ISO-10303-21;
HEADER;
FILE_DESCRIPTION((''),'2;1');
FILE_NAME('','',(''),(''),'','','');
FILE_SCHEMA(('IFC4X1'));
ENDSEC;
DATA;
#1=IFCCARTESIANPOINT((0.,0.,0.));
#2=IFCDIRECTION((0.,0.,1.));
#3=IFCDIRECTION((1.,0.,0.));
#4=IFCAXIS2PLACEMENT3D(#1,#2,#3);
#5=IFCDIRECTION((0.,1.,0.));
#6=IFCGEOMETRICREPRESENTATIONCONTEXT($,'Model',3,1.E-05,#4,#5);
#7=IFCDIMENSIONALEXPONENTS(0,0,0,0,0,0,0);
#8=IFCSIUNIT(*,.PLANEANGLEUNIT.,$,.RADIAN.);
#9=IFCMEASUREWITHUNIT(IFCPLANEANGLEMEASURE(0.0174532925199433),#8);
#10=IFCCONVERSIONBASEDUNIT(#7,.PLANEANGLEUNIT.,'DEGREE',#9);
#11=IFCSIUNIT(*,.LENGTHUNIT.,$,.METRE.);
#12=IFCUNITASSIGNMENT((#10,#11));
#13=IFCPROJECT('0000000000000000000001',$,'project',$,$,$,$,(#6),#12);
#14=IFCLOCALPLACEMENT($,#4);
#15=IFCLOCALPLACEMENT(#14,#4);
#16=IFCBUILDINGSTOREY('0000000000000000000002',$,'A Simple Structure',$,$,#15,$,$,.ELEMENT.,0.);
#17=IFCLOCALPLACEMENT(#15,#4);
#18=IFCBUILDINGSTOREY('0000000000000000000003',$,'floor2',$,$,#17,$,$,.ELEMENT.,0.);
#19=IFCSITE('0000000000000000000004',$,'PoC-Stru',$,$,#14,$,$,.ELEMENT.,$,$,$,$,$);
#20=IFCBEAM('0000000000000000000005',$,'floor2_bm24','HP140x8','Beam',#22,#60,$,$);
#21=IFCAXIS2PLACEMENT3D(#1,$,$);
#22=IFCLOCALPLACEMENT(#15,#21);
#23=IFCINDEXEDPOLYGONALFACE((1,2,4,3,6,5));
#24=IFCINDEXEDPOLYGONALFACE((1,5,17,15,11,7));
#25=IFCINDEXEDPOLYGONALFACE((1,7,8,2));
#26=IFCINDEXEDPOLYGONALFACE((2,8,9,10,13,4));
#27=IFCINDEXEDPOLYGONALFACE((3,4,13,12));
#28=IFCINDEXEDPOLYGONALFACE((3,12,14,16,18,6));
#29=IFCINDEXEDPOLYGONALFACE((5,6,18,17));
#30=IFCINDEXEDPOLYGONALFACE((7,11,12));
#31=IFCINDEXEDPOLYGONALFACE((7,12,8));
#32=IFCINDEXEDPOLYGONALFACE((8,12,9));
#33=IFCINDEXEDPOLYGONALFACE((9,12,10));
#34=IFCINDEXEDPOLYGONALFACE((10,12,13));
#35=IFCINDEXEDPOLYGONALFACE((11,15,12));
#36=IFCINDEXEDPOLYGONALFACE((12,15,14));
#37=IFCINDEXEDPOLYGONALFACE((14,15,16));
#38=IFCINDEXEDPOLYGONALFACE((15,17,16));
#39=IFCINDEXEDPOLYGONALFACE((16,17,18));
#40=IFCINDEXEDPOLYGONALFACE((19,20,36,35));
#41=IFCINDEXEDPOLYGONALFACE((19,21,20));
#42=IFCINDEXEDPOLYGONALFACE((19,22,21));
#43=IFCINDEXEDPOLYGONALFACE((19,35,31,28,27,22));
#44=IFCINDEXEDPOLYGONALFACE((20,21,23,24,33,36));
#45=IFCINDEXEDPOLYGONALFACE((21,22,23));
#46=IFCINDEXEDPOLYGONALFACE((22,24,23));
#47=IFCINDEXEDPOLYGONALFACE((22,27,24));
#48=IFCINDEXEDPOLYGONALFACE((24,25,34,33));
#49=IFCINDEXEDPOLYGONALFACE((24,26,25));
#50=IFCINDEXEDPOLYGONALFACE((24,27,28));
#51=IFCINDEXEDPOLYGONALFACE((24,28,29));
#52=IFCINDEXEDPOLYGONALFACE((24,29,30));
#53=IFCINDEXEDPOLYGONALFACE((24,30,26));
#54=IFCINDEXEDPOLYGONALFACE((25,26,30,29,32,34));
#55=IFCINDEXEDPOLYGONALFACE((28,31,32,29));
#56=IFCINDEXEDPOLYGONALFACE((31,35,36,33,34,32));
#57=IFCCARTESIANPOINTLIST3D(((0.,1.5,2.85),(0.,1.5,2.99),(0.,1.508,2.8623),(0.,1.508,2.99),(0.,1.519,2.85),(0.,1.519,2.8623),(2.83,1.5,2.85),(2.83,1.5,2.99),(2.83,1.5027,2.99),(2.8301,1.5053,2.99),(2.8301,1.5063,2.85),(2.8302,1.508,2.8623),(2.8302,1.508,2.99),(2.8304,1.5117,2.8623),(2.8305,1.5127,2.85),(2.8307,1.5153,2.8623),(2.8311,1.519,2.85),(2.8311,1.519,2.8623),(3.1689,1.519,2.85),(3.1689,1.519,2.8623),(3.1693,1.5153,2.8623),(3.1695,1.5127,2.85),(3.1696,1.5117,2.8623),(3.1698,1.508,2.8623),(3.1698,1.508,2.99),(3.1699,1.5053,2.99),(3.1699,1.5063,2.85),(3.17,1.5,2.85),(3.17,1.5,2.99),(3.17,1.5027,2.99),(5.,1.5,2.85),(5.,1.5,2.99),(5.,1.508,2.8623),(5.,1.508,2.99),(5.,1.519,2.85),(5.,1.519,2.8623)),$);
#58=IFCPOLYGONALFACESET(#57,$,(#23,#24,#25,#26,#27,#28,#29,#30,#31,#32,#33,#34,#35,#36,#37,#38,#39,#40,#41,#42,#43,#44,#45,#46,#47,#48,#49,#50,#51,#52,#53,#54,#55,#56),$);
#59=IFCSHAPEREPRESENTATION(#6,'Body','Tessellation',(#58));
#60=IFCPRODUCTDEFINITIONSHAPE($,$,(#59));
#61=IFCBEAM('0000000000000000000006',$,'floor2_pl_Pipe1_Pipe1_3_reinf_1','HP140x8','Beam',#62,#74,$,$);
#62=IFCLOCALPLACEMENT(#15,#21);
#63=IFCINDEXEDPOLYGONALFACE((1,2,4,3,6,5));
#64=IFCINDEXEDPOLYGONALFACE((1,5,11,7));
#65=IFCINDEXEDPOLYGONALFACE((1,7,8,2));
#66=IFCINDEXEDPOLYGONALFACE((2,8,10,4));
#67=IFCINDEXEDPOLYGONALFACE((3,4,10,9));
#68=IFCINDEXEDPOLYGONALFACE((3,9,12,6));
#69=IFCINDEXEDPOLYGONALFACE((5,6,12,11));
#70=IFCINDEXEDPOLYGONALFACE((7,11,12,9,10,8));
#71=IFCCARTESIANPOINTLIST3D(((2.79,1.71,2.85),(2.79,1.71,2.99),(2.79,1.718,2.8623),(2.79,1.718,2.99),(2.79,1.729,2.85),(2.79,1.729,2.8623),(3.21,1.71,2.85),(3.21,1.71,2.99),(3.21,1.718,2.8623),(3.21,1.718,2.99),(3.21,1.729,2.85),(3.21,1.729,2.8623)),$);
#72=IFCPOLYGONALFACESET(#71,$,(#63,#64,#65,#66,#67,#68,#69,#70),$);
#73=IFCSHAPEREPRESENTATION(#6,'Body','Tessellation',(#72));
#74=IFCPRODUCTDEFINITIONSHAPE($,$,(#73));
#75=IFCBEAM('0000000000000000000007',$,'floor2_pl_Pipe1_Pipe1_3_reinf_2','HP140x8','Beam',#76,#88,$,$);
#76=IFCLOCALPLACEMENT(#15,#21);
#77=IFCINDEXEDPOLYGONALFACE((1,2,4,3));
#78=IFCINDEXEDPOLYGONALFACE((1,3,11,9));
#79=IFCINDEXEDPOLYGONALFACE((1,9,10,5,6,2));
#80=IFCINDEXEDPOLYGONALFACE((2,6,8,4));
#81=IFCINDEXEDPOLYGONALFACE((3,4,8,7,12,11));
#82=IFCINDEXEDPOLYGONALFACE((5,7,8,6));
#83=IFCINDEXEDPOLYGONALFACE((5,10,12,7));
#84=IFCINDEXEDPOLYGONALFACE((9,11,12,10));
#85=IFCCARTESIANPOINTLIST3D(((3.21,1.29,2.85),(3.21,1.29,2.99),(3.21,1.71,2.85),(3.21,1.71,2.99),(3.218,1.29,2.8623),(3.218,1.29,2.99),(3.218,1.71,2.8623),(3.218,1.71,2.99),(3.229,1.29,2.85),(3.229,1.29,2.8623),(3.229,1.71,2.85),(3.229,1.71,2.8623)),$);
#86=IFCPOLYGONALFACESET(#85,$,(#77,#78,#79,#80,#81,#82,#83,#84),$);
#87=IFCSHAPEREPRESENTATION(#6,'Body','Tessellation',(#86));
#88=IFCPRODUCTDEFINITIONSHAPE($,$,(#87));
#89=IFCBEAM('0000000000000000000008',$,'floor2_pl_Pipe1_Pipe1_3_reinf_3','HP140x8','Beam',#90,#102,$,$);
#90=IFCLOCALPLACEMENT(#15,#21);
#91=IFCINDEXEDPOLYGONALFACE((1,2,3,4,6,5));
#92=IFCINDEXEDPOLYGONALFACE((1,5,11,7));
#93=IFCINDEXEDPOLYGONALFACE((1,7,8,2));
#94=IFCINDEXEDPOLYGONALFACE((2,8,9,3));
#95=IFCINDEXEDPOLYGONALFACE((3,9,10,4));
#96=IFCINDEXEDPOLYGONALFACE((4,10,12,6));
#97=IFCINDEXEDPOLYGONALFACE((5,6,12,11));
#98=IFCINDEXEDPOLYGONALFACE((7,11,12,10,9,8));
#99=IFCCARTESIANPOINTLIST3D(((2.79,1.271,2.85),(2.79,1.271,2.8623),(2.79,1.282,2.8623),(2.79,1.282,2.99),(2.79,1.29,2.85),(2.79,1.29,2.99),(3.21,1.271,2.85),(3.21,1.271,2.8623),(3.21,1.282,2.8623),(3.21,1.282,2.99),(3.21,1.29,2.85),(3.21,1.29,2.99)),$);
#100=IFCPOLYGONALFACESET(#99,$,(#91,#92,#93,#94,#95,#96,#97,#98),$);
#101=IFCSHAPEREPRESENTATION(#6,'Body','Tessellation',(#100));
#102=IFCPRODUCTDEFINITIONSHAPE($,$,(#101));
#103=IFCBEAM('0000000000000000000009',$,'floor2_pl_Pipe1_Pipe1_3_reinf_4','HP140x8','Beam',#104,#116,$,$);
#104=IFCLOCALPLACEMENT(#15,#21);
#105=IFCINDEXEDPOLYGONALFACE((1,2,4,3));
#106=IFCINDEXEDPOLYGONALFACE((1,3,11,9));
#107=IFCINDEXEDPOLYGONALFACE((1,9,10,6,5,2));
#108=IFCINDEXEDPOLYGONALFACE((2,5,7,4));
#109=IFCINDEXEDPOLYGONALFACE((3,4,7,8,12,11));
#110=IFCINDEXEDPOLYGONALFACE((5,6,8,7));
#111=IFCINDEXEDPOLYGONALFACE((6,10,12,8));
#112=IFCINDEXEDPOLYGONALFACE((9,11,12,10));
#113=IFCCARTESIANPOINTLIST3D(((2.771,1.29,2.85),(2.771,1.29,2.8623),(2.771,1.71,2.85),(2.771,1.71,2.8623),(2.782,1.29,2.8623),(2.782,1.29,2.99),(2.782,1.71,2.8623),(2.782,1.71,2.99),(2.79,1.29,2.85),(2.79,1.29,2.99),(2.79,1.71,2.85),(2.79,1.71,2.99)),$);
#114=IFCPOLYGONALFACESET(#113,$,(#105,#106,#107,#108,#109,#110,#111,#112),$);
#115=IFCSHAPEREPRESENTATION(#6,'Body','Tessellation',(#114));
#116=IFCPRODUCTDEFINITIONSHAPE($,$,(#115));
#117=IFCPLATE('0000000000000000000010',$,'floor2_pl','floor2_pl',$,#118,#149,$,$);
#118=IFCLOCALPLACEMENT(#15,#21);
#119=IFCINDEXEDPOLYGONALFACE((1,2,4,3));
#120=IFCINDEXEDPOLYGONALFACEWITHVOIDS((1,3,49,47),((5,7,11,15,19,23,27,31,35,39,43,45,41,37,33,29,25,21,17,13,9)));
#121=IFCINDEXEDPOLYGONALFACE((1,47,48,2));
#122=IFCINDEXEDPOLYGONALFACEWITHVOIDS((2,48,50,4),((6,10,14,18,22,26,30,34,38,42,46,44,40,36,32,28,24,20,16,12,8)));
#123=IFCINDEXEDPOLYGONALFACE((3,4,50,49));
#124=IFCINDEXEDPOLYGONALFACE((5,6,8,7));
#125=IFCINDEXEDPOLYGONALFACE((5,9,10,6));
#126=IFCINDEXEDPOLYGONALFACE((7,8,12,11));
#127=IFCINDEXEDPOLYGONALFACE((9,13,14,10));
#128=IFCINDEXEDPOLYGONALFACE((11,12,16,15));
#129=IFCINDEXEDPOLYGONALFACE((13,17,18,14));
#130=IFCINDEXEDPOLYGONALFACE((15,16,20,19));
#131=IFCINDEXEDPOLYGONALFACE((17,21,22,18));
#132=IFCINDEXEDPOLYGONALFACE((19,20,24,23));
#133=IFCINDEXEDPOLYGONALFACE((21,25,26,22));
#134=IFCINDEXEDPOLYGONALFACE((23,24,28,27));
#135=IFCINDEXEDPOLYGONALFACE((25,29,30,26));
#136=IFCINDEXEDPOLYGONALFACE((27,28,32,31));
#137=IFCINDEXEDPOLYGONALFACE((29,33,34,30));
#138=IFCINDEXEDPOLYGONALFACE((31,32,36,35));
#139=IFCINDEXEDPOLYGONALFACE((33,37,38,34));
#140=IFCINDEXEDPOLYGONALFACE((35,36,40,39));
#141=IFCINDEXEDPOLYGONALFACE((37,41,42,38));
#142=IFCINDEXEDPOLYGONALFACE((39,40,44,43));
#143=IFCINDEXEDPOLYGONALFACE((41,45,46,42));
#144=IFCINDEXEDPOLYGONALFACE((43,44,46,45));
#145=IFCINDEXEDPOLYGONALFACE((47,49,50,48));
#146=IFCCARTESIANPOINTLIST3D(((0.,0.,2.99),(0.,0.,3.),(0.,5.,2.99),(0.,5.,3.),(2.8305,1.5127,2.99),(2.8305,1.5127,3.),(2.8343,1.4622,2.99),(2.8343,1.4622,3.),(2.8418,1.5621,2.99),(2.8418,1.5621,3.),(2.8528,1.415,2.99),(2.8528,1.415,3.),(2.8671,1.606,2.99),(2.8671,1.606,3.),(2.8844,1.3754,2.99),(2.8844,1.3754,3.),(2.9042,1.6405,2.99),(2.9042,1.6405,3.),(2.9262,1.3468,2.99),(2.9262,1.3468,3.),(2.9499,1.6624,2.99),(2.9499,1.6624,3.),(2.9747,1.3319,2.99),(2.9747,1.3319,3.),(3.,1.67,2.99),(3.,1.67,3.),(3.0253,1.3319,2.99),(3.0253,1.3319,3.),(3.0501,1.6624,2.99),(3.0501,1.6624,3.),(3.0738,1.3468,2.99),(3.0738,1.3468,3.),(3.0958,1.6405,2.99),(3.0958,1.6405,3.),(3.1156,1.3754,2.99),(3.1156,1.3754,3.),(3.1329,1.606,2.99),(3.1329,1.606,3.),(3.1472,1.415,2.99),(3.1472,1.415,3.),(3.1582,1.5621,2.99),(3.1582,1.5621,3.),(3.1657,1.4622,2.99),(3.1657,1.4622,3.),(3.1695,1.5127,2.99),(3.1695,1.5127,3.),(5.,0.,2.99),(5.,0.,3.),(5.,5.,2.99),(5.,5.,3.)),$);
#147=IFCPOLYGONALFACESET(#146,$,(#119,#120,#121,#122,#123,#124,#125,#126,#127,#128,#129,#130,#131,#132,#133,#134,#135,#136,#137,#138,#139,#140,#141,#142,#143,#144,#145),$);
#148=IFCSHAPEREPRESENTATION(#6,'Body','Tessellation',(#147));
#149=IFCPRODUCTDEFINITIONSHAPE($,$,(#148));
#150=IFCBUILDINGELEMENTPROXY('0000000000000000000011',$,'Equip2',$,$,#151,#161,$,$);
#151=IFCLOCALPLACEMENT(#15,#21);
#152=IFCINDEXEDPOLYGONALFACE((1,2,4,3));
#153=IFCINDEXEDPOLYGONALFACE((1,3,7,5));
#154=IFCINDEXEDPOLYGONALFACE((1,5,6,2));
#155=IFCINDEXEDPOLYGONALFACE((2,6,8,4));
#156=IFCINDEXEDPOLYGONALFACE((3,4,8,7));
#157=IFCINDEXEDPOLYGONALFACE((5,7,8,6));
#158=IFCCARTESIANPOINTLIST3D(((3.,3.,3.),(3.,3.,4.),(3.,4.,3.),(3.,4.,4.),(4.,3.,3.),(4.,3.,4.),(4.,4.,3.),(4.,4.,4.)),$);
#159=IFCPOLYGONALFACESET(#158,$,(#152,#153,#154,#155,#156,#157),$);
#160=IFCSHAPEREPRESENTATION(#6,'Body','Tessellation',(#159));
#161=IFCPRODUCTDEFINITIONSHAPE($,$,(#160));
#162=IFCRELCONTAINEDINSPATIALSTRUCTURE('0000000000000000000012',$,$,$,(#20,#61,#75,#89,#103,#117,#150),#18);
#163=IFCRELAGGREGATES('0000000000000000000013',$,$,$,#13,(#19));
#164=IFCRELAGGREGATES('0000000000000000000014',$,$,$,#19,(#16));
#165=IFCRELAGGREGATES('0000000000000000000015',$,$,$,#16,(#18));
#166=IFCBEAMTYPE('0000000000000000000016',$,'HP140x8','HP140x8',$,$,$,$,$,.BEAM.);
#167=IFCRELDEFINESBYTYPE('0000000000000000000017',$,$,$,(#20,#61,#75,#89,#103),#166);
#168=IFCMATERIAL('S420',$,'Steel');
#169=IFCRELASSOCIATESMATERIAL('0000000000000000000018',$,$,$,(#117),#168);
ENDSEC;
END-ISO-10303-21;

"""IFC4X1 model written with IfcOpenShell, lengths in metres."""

from ifc_helpers import new_model, entity, si_unit, converted_unit, direction, frame, origin, origin_with_axes, place, context, project, spatial, polyline, line, indexed_curve, circle, outline, extrude, material, type_object, element, save


model = new_model("IFC4X1")

# Units and contexts
model_context = context("Model", 3, precision=1e-05, world=origin_with_axes(), true_north=direction((0.0, 1.0, 0.0)))
ifc_project = project(units=[converted_unit("PLANEANGLEUNIT", "DEGREE", entity("IfcPlaneAngleMeasure", 0.0174532925199433), si_unit("PLANEANGLEUNIT", "RADIAN"), dimensions=[0, 0, 0, 0, 0, 0, 0]), si_unit("LENGTHUNIT", "METRE")], contexts=[model_context])

# Site, storeys
site_placement = place(None, origin_with_axes())
site = spatial("IfcSite", under=ifc_project, at=site_placement, Name="PoC-Stru", CompositionType="ELEMENT")
storey_1_placement = place(site_placement, origin_with_axes())
storey_1 = spatial("IfcBuildingStorey", under=site, at=storey_1_placement, Name="A Simple Structure", CompositionType="ELEMENT", Elevation=0.0)
storey_2_placement = place(storey_1_placement, origin_with_axes())
storey_2 = spatial("IfcBuildingStorey", under=storey_1, at=storey_2_placement, Name="floor2", CompositionType="ELEMENT", Elevation=0.0)

# Beam, opening
beam_type = type_object("IfcBeamType", Name="HP140x8", Description="HP140x8", PredefinedType="BEAM")
plate_placement = place(storey_2_placement, origin_with_axes())
beam_1_placement = place(plate_placement, frame((0.0, 1.5, 2.99), z_axis=(1.0, 0.0, 0.0), x_axis=(0.0, 1.0, 0.0)))
beam_1 = element("IfcBeam", 1, at=beam_1_placement, inside=storey_2, type_object=beam_type, Name="floor2_bm24", Description="HP140x8", ObjectType="Beam", context=model_context, shape_type="SweptSolid", body=[
    extrude(outline(polyline([(0.0, 0.0), (0.008, 0.0), (0.008, -0.1277), (0.019, -0.1277), (0.019, -0.14), (0.0, -0.14)])), origin(), (0.0, 0.0, 1.0), 5.0),
])
opening_1_placement = place(storey_2_placement, origin_with_axes())
element("IfcOpeningElement", 2, at=opening_1_placement, cuts=beam_1, context=model_context, shape_type="SweptSolid", body=[
    extrude(circle(Radius=0.17), frame((3.0, 1.5, 0.6301), z_axis=(0.0, 0.0, 1.0), x_axis=(0.0, 1.0, 0.0)), (0.0, 0.0, 1.0), 2.7399),
])

# Beams
placement_1 = place(storey_2_placement, origin_with_axes())
beam_2_placement = place(placement_1, frame((2.79, 1.71, 2.99), z_axis=(1.0, 0.0, 0.0), x_axis=(0.0, 1.0, 0.0)))
element("IfcBeam", 3, at=beam_2_placement, inside=storey_2, type_object=beam_type, Name="floor2_pl_Pipe1_Pipe1_3_reinf_1", Description="HP140x8", ObjectType="Beam", context=model_context, shape_type="SweptSolid", body=[
    extrude(outline(polyline([(0.0, 0.0), (0.008, 0.0), (0.008, -0.1277), (0.019, -0.1277), (0.019, -0.14), (0.0, -0.14)])), origin(), (0.0, 0.0, 1.0), 0.42),
])
placement_2 = place(storey_2_placement, origin_with_axes())
beam_3_placement = place(placement_2, frame((3.21, 1.71, 2.99), z_axis=(0.0, -1.0, 0.0), x_axis=(1.0, 0.0, 0.0)))
element("IfcBeam", 4, at=beam_3_placement, inside=storey_2, type_object=beam_type, Name="floor2_pl_Pipe1_Pipe1_3_reinf_2", Description="HP140x8", ObjectType="Beam", context=model_context, shape_type="SweptSolid", body=[
    extrude(outline(polyline([(0.0, 0.0), (0.008, 0.0), (0.008, -0.1277), (0.019, -0.1277), (0.019, -0.14), (0.0, -0.14)])), origin(), (0.0, 0.0, 1.0), 0.42),
])
placement_3 = place(storey_2_placement, origin_with_axes())
beam_4_placement = place(placement_3, frame((3.21, 1.29, 2.99), z_axis=(-1.0, 0.0, 0.0), x_axis=(0.0, -1.0, 0.0)))
element("IfcBeam", 5, at=beam_4_placement, inside=storey_2, type_object=beam_type, Name="floor2_pl_Pipe1_Pipe1_3_reinf_3", Description="HP140x8", ObjectType="Beam", context=model_context, shape_type="SweptSolid", body=[
    extrude(outline(polyline([(0.0, 0.0), (0.008, 0.0), (0.008, -0.1277), (0.019, -0.1277), (0.019, -0.14), (0.0, -0.14)])), origin(), (0.0, 0.0, 1.0), 0.42),
])
placement_4 = place(storey_2_placement, origin_with_axes())
beam_5_placement = place(placement_4, frame((2.79, 1.29, 2.99), z_axis=(0.0, 1.0, 0.0), x_axis=(-1.0, 0.0, 0.0)))
element("IfcBeam", 6, at=beam_5_placement, inside=storey_2, type_object=beam_type, Name="floor2_pl_Pipe1_Pipe1_3_reinf_4", Description="HP140x8", ObjectType="Beam", context=model_context, shape_type="SweptSolid", body=[
    extrude(outline(polyline([(0.0, 0.0), (0.008, 0.0), (0.008, -0.1277), (0.019, -0.1277), (0.019, -0.14), (0.0, -0.14)])), origin(), (0.0, 0.0, 1.0), 0.42),
])

# Plate, opening
ifc_material = material(Name="S420", Category="Steel")
plate = element("IfcPlate", 7, at=plate_placement, inside=storey_2, material=ifc_material, Name="floor2_pl", Description="floor2_pl", context=model_context, shape_type="SolidModel", body=[
    extrude(outline(indexed_curve([(0.0, 5.0, 3.0), (0.0, 0.0, 3.0), (5.0, 0.0, 3.0), (5.0, 5.0, 3.0)], segments=[line(1, 2), line(2, 3), line(3, 4), line(4, 1)])), origin_with_axes(), (0.0, 0.0, -1.0), 0.01),
])
opening_2_placement = place(storey_2_placement, origin_with_axes())
element("IfcOpeningElement", 8, at=opening_2_placement, cuts=plate, context=model_context, shape_type="SweptSolid", body=[
    extrude(circle(Radius=0.17), frame((3.0, 1.5, 0.6301), z_axis=(0.0, 0.0, 1.0), x_axis=(0.0, 1.0, 0.0)), (0.0, 0.0, 1.0), 2.7399),
])

# Building element proxy, opening
proxy_placement = place(storey_2_placement, origin_with_axes())
proxy = element("IfcBuildingElementProxy", 9, at=proxy_placement, inside=storey_2, Name="Equip2", context=model_context, shape_type="SweptSolid", body=[
    extrude(outline(polyline([(3.0, 3.0, 3.0), (3.0, 4.0, 3.0), (4.0, 4.0, 3.0), (4.0, 3.0, 3.0)])), origin_with_axes(), (0.0, 0.0, 1.0), 1.0),
])
opening_3_placement = place(storey_2_placement, origin_with_axes())
element("IfcOpeningElement", 10, at=opening_3_placement, cuts=proxy, context=model_context, shape_type="SweptSolid", body=[
    extrude(circle(Radius=0.17), frame((3.0, 1.5, 0.6301), z_axis=(0.0, 0.0, 1.0), x_axis=(0.0, 1.0, 0.0)), (0.0, 0.0, 1.0), 2.7399),
])

save(model, "model.ifc")
